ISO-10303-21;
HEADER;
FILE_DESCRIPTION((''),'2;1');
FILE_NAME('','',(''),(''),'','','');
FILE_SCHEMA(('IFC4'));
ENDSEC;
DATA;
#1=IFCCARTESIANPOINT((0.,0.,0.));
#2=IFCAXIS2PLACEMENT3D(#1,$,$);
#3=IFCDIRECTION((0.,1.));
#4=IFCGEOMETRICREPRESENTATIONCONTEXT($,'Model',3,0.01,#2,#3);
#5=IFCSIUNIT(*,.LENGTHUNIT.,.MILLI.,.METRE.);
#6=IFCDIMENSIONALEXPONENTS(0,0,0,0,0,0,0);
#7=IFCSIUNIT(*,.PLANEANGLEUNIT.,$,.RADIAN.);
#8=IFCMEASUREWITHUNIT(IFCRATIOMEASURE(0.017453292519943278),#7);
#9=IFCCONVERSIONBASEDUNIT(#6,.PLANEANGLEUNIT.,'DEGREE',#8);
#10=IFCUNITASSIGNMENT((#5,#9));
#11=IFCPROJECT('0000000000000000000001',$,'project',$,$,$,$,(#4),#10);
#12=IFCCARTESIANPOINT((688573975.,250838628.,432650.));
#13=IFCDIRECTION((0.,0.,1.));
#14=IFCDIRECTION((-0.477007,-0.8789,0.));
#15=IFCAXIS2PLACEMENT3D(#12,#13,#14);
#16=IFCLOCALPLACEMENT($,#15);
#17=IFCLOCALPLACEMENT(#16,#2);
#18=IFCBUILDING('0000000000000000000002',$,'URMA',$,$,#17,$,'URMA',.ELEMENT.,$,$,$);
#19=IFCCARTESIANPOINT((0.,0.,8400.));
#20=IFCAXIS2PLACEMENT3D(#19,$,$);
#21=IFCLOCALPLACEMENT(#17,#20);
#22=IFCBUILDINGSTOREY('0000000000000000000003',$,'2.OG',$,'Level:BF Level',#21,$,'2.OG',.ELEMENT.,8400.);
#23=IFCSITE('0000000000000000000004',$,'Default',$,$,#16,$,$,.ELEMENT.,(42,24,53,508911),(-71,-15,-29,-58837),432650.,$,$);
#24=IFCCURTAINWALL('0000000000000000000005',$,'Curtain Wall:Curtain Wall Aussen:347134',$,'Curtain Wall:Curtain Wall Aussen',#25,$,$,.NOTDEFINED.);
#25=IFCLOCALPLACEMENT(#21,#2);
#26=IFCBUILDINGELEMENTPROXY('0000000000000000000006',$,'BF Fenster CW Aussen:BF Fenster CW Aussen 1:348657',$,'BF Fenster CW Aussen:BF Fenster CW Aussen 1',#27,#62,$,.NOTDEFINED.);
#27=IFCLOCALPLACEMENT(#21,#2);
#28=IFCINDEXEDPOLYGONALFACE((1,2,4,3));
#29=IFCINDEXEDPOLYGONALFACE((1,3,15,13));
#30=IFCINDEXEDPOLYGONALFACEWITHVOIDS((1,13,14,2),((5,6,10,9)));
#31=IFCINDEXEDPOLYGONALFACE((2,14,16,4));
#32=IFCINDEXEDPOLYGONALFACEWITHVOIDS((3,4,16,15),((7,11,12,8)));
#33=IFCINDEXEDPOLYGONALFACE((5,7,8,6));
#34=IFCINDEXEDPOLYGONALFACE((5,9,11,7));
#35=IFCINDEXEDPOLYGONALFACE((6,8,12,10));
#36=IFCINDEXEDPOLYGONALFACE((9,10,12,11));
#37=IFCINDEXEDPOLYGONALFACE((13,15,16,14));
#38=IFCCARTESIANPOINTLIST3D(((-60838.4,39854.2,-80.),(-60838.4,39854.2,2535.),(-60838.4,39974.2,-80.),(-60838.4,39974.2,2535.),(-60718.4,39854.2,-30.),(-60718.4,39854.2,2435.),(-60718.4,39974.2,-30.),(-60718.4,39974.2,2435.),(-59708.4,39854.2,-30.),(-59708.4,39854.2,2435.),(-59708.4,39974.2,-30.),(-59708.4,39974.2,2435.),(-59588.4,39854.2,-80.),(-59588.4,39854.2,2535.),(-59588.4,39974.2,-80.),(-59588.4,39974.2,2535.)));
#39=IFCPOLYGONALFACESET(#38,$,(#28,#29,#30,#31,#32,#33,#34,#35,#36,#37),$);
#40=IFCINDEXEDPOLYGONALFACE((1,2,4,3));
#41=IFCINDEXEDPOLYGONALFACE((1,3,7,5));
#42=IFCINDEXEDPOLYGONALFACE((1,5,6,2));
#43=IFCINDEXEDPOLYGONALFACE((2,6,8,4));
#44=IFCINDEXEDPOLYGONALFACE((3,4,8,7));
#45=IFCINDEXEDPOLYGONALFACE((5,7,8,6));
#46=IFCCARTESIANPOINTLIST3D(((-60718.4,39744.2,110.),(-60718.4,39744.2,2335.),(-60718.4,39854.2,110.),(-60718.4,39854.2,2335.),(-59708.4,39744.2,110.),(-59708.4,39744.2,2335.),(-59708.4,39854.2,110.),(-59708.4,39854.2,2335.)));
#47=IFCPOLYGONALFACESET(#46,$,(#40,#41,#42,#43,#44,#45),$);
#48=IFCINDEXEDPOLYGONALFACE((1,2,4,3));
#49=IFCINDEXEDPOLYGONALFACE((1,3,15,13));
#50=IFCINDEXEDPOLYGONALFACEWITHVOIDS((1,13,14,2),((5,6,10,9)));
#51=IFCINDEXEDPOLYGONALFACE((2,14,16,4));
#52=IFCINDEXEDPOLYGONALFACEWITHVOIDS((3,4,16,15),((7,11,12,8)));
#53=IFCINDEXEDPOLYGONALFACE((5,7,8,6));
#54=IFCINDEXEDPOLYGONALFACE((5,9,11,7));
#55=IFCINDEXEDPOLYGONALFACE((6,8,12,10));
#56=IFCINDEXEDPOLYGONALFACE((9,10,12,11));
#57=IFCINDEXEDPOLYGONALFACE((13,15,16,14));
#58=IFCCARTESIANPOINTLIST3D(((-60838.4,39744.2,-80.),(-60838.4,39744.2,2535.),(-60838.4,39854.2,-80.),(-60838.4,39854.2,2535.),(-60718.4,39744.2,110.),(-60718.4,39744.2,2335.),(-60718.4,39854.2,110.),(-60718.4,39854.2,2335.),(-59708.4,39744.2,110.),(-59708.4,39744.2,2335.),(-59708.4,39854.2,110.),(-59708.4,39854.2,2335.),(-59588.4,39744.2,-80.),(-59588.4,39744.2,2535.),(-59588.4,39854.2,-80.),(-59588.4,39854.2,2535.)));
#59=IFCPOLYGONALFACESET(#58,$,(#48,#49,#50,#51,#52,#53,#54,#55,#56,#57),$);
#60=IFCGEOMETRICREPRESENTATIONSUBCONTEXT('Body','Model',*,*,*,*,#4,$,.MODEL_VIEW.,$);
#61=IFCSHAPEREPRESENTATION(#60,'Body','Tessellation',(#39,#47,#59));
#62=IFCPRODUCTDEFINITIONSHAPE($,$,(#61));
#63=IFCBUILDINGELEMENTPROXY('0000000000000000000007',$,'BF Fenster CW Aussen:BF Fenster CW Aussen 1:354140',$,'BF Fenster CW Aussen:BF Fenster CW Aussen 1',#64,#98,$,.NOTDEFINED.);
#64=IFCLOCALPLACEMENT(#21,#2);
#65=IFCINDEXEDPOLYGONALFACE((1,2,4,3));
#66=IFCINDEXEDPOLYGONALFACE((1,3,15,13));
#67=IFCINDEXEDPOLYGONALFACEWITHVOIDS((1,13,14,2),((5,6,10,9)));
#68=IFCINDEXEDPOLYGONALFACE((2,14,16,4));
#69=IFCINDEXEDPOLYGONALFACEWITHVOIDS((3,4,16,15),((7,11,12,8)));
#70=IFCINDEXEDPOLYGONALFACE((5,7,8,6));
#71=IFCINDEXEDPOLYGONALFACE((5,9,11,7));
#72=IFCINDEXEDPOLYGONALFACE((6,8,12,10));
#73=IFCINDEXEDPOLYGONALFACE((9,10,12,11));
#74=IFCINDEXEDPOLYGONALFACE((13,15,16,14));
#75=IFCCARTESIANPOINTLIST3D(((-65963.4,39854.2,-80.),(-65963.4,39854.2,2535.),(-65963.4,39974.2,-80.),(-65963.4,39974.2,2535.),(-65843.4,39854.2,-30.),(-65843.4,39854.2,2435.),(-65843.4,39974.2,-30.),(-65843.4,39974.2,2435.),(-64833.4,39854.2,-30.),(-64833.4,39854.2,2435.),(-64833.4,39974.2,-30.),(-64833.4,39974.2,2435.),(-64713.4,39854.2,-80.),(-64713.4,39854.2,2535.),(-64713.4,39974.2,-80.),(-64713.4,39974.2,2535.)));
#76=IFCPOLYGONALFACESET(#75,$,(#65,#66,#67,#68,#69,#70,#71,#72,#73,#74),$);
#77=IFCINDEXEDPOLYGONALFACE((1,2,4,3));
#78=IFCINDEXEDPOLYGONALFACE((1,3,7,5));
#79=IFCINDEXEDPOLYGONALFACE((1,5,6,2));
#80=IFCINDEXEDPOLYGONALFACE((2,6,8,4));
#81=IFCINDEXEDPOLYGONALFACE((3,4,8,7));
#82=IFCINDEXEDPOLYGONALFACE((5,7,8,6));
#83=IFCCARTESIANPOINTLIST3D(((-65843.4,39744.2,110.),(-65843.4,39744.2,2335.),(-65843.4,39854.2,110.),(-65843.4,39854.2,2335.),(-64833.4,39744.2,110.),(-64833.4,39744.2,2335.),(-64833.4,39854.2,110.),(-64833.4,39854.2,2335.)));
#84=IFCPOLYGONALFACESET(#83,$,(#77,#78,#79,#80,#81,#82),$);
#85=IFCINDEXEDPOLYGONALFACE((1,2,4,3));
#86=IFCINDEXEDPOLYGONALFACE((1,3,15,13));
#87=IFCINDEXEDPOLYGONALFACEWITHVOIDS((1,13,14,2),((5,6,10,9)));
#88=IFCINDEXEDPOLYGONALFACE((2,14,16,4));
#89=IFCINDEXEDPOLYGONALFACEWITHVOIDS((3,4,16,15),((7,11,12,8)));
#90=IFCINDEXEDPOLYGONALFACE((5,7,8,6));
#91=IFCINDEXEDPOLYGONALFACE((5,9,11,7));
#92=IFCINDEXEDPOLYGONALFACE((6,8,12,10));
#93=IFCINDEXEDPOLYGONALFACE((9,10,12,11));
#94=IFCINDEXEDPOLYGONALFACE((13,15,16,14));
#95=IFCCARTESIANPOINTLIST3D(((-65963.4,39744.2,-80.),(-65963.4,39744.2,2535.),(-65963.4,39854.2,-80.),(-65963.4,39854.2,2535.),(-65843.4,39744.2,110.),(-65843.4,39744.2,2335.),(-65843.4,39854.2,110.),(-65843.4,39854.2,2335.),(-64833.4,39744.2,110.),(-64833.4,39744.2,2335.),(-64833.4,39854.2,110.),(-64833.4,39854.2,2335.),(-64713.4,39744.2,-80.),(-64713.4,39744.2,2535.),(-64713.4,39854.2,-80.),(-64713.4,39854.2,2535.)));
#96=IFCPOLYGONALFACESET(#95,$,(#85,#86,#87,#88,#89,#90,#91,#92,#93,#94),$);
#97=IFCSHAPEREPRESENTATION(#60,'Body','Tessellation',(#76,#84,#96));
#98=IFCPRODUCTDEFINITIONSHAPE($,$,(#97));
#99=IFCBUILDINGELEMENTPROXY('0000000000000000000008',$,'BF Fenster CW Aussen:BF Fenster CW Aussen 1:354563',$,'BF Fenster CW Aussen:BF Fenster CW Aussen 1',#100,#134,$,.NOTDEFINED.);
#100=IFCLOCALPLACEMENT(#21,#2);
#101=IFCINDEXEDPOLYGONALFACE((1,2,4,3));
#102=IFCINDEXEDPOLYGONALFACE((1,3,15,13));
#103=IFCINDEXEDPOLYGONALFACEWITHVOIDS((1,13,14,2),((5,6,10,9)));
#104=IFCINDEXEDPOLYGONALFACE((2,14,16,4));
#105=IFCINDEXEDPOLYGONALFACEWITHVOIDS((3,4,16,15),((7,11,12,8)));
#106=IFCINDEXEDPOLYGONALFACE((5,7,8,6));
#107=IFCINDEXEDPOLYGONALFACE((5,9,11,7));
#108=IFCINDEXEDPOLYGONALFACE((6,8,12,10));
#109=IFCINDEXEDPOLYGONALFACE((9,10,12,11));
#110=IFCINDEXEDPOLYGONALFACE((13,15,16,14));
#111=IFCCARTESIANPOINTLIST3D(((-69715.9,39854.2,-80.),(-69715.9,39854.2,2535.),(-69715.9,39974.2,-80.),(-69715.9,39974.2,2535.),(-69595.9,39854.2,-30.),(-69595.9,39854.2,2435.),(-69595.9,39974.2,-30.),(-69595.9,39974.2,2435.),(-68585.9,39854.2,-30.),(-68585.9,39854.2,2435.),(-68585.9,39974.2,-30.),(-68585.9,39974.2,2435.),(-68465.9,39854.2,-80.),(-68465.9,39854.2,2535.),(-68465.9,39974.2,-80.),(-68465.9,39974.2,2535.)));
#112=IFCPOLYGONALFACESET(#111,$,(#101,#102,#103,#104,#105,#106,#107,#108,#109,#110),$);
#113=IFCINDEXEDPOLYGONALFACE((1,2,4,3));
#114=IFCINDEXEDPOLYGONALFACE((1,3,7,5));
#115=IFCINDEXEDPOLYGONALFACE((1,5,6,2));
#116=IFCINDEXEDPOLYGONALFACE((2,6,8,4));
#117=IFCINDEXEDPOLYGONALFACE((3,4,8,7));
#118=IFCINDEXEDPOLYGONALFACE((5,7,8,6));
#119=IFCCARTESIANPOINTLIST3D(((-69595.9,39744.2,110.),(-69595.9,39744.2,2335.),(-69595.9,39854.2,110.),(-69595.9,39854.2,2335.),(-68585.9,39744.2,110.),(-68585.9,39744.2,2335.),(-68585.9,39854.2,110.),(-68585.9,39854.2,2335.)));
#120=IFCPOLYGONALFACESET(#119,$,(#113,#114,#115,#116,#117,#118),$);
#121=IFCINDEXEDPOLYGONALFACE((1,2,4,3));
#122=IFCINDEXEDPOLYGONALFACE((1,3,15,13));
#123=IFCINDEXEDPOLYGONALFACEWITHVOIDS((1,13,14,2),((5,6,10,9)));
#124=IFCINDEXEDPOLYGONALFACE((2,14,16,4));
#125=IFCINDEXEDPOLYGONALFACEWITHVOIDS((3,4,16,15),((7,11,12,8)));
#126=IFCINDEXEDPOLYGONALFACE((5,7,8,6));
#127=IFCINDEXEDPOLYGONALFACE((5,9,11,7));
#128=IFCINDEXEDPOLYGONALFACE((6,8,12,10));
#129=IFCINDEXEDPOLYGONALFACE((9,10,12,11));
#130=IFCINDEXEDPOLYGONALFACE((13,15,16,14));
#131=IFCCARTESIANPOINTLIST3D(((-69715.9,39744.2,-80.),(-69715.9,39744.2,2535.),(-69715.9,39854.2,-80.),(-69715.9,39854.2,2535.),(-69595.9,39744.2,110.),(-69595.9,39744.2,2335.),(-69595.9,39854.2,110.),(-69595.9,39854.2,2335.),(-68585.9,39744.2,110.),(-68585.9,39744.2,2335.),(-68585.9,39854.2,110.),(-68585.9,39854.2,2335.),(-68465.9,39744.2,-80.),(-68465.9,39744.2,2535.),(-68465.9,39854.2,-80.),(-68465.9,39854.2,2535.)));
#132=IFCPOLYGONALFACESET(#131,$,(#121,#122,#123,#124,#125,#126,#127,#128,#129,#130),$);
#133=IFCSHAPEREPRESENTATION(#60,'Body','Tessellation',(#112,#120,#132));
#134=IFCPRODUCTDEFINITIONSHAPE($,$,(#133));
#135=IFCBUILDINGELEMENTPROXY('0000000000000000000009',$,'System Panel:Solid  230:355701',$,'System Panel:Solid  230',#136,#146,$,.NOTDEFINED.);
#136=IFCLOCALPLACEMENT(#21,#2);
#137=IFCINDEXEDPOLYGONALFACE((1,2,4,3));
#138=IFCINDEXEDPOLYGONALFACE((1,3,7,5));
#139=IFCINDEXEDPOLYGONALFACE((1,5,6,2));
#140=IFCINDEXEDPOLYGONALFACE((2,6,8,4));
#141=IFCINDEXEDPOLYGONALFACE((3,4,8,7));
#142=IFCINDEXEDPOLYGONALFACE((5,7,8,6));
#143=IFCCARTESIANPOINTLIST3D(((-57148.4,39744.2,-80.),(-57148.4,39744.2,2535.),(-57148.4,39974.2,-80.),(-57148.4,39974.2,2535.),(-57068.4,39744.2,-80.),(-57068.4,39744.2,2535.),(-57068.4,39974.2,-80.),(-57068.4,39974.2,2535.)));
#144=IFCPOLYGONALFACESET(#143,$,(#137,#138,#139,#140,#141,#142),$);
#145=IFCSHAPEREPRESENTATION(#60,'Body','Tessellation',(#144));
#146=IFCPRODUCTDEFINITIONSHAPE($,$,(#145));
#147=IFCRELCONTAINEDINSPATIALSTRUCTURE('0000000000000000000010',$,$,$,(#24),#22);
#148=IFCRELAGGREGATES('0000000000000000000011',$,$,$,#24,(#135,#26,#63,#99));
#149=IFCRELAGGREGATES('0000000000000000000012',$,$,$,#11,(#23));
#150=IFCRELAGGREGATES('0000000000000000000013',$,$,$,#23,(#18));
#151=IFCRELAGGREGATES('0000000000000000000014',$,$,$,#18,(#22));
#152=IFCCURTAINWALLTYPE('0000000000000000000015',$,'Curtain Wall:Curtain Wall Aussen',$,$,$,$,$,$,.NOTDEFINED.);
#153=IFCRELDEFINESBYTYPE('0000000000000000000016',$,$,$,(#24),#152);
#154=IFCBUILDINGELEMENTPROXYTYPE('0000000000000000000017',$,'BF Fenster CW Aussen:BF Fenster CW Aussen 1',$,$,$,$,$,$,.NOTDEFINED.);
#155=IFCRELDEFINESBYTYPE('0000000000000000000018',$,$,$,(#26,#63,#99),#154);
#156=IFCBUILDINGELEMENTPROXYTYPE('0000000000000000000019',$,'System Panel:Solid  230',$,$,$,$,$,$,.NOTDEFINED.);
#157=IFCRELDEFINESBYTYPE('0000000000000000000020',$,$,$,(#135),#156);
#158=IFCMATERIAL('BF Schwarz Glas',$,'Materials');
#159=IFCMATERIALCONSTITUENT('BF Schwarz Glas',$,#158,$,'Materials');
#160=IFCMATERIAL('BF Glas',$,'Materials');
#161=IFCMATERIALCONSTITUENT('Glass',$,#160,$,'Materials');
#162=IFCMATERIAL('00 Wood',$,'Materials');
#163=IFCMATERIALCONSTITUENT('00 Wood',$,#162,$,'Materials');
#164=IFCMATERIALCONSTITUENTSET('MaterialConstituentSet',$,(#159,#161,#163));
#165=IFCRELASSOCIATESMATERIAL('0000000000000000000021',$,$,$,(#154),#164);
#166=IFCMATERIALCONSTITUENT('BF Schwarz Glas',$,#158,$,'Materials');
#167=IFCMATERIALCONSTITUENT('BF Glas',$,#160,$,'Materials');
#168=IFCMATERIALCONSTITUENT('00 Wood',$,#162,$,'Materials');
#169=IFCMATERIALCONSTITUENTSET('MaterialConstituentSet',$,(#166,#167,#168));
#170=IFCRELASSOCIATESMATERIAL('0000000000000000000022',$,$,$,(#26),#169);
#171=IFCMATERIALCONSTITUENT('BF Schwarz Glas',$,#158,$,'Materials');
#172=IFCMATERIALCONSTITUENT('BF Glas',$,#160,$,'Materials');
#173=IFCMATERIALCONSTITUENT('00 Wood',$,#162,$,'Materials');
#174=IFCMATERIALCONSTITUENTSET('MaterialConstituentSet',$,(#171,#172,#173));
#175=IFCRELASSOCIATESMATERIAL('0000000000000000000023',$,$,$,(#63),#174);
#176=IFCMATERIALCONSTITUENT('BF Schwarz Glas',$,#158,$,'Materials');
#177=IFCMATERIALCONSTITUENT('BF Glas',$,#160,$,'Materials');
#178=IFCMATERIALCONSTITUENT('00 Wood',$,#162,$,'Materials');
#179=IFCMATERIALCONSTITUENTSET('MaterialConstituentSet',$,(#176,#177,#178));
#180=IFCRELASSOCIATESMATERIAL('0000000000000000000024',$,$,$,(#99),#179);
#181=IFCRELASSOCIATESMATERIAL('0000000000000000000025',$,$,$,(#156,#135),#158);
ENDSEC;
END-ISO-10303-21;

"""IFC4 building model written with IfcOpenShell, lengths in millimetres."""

from ifc_helpers import new_model, entity, si_unit, converted_unit, direction, frame, origin, place, context, subcontext, project, spatial, indexed_curve, outline, extrude, source, transform, mapped, material, constituent, constituent_set, type_object, type_shapes, element, aggregate, save


model = new_model("IFC4")

# Units and contexts
model_context = context("Model", 3, precision=0.01, world=origin(), true_north=direction((0.0, 1.0)))
body_context = subcontext(model_context, "Body", "Model", "MODEL_VIEW")
ifc_project = project(units=[si_unit("LENGTHUNIT", "METRE", prefix="MILLI"), converted_unit("PLANEANGLEUNIT", "DEGREE", entity("IfcRatioMeasure", 0.017453292519943278), si_unit("PLANEANGLEUNIT", "RADIAN"), dimensions=[0, 0, 0, 0, 0, 0, 0])], contexts=[model_context])

# Site, building, storey
site_placement = place(None, frame((688573975.0, 250838628.0, 432650.0), z_axis=(0.0, 0.0, 1.0), x_axis=(-0.477007, -0.8789, 0.0)))
site = spatial("IfcSite", under=ifc_project, at=site_placement, Name="Default", CompositionType="ELEMENT", RefLatitude=(42, 24, 53, 508911), RefLongitude=(-71, -15, -29, -58837), RefElevation=432650.0)
building_placement = place(site_placement, origin())
building = spatial("IfcBuilding", under=site, at=building_placement, Name="URMA", LongName="URMA", CompositionType="ELEMENT")
storey_placement = place(building_placement, frame((0.0, 0.0, 8400.0)))
storey = spatial("IfcBuildingStorey", under=building, at=storey_placement, Name="2.OG", ObjectType="Level:BF Level", LongName="2.OG", CompositionType="ELEMENT", Elevation=8400.0)

# Shared definitions
curtain_wall_type = type_object("IfcCurtainWallType", Name="Curtain Wall:Curtain Wall Aussen", PredefinedType="NOTDEFINED")

# Curtain wall, building element proxies
curtain_wall_1_placement = place(storey_placement, frame((0.0, 0.0, -8400.0)))
curtain_wall_1 = element("IfcCurtainWall", 1, at=curtain_wall_1_placement, inside=storey, type_object=curtain_wall_type, Name="Curtain Wall:Curtain Wall Aussen:347134", ObjectType="Curtain Wall:Curtain Wall Aussen", PredefinedType="NOTDEFINED")
ifc_material_1 = material(Name="BF Schwarz Glas", Category="Materials")
ifc_material_2 = material(Name="BF Glas", Category="Materials")
ifc_material_3 = material(Name="00 Wood", Category="Materials")
ifc_constituent_1 = constituent(ifc_material_1, Name="BF Schwarz Glas", Category="Materials")
ifc_constituent_2 = constituent(ifc_material_2, Name="Glass", Category="Materials")
ifc_constituent_3 = constituent(ifc_material_3, Name="00 Wood", Category="Materials")
ifc_constituent_set_1 = constituent_set(constituents=[ifc_constituent_1, ifc_constituent_2, ifc_constituent_3], Name="MaterialConstituentSet")
building_element_proxy_type_1 = type_object("IfcBuildingElementProxyType", Name="BF Fenster CW Aussen:BF Fenster CW Aussen 1", PredefinedType="NOTDEFINED", material=ifc_constituent_set_1)
shared_shape_1 = source(origin(), body_context, "Body", "SweptSolid", [
    extrude(outline(indexed_curve([(-625.0, -1307.5), (625.0, -1307.5), (625.0, 1307.5), (-625.0, 1307.5), (-625.0, -1307.5)], self_intersect=False), holes=[indexed_curve([(-505.0, -1207.5), (-505.0, 1257.5), (505.0, 1257.5), (505.0, -1207.5), (-505.0, -1207.5)], self_intersect=False)]), frame((0.0, -120.0, 1307.5), z_axis=(0.0, 1.0, 0.0), x_axis=(1.0, 0.0, 0.0)), (0.0, 0.0, 1.0), 120.0),
    extrude(outline(indexed_curve([(-55.0, -505.0), (55.0, -505.0), (55.0, 505.0), (-55.0, 505.0), (-55.0, -505.0)], self_intersect=False)), frame((0.0, 55.0, 190.0), z_axis=(0.0, 0.0, 1.0), x_axis=(0.0, 1.0, 0.0)), (0.0, 0.0, 1.0), 2225.0),
    extrude(outline(indexed_curve([(-625.0, -1307.5), (625.0, -1307.5), (625.0, 1307.5), (-625.0, 1307.5), (-625.0, -1307.5)], self_intersect=False), holes=[indexed_curve([(-505.0, -1107.5), (-505.0, 1117.5), (505.0, 1117.5), (505.0, -1107.5), (-505.0, -1107.5)], self_intersect=False)]), frame((0.0, 0.0, 1307.5), z_axis=(0.0, 1.0, 0.0), x_axis=(1.0, 0.0, 0.0)), (0.0, 0.0, 1.0), 110.0),
])
type_shapes(building_element_proxy_type_1, [shared_shape_1])
ifc_constituent_4 = constituent(ifc_material_1, Name="BF Schwarz Glas", Category="Materials")
ifc_constituent_5 = constituent(ifc_material_2, Name="BF Glas", Category="Materials")
ifc_constituent_6 = constituent(ifc_material_3, Name="00 Wood", Category="Materials")
ifc_constituent_set_2 = constituent_set(constituents=[ifc_constituent_4, ifc_constituent_5, ifc_constituent_6], Name="MaterialConstituentSet")
proxy_1_placement = place(storey_placement, frame((-60213.4, 39854.2, -80.0), z_axis=(0.0, 0.0, 1.0), x_axis=(-1.0, 0.0, 0.0)))
proxy_1 = element("IfcBuildingElementProxy", 2, at=proxy_1_placement, type_object=building_element_proxy_type_1, material=ifc_constituent_set_2, Name="BF Fenster CW Aussen:BF Fenster CW Aussen 1:348657", ObjectType="BF Fenster CW Aussen:BF Fenster CW Aussen 1", PredefinedType="NOTDEFINED", context=body_context, shape_type="MappedRepresentation", body=[
    mapped(shared_shape_1, transform((0.0, 0.0, 0.0), scale=1.0)),
])
ifc_constituent_7 = constituent(ifc_material_1, Name="BF Schwarz Glas", Category="Materials")
ifc_constituent_8 = constituent(ifc_material_2, Name="BF Glas", Category="Materials")
ifc_constituent_9 = constituent(ifc_material_3, Name="00 Wood", Category="Materials")
ifc_constituent_set_3 = constituent_set(constituents=[ifc_constituent_7, ifc_constituent_8, ifc_constituent_9], Name="MaterialConstituentSet")
proxy_2_placement = place(storey_placement, frame((-65338.4, 39854.2, -80.0), z_axis=(0.0, 0.0, 1.0), x_axis=(-1.0, 0.0, 0.0)))
proxy_2 = element("IfcBuildingElementProxy", 3, at=proxy_2_placement, type_object=building_element_proxy_type_1, material=ifc_constituent_set_3, Name="BF Fenster CW Aussen:BF Fenster CW Aussen 1:354140", ObjectType="BF Fenster CW Aussen:BF Fenster CW Aussen 1", PredefinedType="NOTDEFINED", context=body_context, shape_type="MappedRepresentation", body=[
    mapped(shared_shape_1, transform((0.0, 0.0, 0.0), scale=1.0)),
])
ifc_constituent_10 = constituent(ifc_material_1, Name="BF Schwarz Glas", Category="Materials")
ifc_constituent_11 = constituent(ifc_material_2, Name="BF Glas", Category="Materials")
ifc_constituent_12 = constituent(ifc_material_3, Name="00 Wood", Category="Materials")
ifc_constituent_set_4 = constituent_set(constituents=[ifc_constituent_10, ifc_constituent_11, ifc_constituent_12], Name="MaterialConstituentSet")
proxy_3_placement = place(storey_placement, frame((-69090.9, 39854.2, -80.0), z_axis=(0.0, 0.0, 1.0), x_axis=(-1.0, 0.0, 0.0)))
proxy_3 = element("IfcBuildingElementProxy", 4, at=proxy_3_placement, type_object=building_element_proxy_type_1, material=ifc_constituent_set_4, Name="BF Fenster CW Aussen:BF Fenster CW Aussen 1:354563", ObjectType="BF Fenster CW Aussen:BF Fenster CW Aussen 1", PredefinedType="NOTDEFINED", context=body_context, shape_type="MappedRepresentation", body=[
    mapped(shared_shape_1, transform((0.0, 0.0, 0.0), scale=1.0)),
])
building_element_proxy_type_2 = type_object("IfcBuildingElementProxyType", Name="System Panel:Solid  230", PredefinedType="NOTDEFINED", material=ifc_material_1)
shared_shape_2 = source(origin(), body_context, "Body", "SweptSolid", [
    extrude(outline(indexed_curve([(-115.0, -40.0), (115.0, -40.0), (115.0, 40.0), (-115.0, 40.0), (-115.0, -40.0)], self_intersect=False)), frame((0.0, -5.0, 0.0), z_axis=(0.0, 0.0, 1.0), x_axis=(0.0, 1.0, 0.0)), (0.0, 0.0, 1.0), 2615.0),
])
type_shapes(building_element_proxy_type_2, [shared_shape_2])
proxy_4_placement = place(storey_placement, frame((-57108.4, 39854.2, -80.0), z_axis=(0.0, 0.0, 1.0), x_axis=(-1.0, 0.0, 0.0)))
proxy_4 = element("IfcBuildingElementProxy", 5, at=proxy_4_placement, type_object=building_element_proxy_type_2, material=ifc_material_1, Name="System Panel:Solid  230:355701", ObjectType="System Panel:Solid  230", PredefinedType="NOTDEFINED", context=body_context, shape_type="MappedRepresentation", body=[
    mapped(shared_shape_2, transform((0.0, 0.0, 0.0), scale=1.0)),
])
aggregate(curtain_wall_1, [proxy_4, proxy_1, proxy_2, proxy_3])

save(model, "model.ifc")
